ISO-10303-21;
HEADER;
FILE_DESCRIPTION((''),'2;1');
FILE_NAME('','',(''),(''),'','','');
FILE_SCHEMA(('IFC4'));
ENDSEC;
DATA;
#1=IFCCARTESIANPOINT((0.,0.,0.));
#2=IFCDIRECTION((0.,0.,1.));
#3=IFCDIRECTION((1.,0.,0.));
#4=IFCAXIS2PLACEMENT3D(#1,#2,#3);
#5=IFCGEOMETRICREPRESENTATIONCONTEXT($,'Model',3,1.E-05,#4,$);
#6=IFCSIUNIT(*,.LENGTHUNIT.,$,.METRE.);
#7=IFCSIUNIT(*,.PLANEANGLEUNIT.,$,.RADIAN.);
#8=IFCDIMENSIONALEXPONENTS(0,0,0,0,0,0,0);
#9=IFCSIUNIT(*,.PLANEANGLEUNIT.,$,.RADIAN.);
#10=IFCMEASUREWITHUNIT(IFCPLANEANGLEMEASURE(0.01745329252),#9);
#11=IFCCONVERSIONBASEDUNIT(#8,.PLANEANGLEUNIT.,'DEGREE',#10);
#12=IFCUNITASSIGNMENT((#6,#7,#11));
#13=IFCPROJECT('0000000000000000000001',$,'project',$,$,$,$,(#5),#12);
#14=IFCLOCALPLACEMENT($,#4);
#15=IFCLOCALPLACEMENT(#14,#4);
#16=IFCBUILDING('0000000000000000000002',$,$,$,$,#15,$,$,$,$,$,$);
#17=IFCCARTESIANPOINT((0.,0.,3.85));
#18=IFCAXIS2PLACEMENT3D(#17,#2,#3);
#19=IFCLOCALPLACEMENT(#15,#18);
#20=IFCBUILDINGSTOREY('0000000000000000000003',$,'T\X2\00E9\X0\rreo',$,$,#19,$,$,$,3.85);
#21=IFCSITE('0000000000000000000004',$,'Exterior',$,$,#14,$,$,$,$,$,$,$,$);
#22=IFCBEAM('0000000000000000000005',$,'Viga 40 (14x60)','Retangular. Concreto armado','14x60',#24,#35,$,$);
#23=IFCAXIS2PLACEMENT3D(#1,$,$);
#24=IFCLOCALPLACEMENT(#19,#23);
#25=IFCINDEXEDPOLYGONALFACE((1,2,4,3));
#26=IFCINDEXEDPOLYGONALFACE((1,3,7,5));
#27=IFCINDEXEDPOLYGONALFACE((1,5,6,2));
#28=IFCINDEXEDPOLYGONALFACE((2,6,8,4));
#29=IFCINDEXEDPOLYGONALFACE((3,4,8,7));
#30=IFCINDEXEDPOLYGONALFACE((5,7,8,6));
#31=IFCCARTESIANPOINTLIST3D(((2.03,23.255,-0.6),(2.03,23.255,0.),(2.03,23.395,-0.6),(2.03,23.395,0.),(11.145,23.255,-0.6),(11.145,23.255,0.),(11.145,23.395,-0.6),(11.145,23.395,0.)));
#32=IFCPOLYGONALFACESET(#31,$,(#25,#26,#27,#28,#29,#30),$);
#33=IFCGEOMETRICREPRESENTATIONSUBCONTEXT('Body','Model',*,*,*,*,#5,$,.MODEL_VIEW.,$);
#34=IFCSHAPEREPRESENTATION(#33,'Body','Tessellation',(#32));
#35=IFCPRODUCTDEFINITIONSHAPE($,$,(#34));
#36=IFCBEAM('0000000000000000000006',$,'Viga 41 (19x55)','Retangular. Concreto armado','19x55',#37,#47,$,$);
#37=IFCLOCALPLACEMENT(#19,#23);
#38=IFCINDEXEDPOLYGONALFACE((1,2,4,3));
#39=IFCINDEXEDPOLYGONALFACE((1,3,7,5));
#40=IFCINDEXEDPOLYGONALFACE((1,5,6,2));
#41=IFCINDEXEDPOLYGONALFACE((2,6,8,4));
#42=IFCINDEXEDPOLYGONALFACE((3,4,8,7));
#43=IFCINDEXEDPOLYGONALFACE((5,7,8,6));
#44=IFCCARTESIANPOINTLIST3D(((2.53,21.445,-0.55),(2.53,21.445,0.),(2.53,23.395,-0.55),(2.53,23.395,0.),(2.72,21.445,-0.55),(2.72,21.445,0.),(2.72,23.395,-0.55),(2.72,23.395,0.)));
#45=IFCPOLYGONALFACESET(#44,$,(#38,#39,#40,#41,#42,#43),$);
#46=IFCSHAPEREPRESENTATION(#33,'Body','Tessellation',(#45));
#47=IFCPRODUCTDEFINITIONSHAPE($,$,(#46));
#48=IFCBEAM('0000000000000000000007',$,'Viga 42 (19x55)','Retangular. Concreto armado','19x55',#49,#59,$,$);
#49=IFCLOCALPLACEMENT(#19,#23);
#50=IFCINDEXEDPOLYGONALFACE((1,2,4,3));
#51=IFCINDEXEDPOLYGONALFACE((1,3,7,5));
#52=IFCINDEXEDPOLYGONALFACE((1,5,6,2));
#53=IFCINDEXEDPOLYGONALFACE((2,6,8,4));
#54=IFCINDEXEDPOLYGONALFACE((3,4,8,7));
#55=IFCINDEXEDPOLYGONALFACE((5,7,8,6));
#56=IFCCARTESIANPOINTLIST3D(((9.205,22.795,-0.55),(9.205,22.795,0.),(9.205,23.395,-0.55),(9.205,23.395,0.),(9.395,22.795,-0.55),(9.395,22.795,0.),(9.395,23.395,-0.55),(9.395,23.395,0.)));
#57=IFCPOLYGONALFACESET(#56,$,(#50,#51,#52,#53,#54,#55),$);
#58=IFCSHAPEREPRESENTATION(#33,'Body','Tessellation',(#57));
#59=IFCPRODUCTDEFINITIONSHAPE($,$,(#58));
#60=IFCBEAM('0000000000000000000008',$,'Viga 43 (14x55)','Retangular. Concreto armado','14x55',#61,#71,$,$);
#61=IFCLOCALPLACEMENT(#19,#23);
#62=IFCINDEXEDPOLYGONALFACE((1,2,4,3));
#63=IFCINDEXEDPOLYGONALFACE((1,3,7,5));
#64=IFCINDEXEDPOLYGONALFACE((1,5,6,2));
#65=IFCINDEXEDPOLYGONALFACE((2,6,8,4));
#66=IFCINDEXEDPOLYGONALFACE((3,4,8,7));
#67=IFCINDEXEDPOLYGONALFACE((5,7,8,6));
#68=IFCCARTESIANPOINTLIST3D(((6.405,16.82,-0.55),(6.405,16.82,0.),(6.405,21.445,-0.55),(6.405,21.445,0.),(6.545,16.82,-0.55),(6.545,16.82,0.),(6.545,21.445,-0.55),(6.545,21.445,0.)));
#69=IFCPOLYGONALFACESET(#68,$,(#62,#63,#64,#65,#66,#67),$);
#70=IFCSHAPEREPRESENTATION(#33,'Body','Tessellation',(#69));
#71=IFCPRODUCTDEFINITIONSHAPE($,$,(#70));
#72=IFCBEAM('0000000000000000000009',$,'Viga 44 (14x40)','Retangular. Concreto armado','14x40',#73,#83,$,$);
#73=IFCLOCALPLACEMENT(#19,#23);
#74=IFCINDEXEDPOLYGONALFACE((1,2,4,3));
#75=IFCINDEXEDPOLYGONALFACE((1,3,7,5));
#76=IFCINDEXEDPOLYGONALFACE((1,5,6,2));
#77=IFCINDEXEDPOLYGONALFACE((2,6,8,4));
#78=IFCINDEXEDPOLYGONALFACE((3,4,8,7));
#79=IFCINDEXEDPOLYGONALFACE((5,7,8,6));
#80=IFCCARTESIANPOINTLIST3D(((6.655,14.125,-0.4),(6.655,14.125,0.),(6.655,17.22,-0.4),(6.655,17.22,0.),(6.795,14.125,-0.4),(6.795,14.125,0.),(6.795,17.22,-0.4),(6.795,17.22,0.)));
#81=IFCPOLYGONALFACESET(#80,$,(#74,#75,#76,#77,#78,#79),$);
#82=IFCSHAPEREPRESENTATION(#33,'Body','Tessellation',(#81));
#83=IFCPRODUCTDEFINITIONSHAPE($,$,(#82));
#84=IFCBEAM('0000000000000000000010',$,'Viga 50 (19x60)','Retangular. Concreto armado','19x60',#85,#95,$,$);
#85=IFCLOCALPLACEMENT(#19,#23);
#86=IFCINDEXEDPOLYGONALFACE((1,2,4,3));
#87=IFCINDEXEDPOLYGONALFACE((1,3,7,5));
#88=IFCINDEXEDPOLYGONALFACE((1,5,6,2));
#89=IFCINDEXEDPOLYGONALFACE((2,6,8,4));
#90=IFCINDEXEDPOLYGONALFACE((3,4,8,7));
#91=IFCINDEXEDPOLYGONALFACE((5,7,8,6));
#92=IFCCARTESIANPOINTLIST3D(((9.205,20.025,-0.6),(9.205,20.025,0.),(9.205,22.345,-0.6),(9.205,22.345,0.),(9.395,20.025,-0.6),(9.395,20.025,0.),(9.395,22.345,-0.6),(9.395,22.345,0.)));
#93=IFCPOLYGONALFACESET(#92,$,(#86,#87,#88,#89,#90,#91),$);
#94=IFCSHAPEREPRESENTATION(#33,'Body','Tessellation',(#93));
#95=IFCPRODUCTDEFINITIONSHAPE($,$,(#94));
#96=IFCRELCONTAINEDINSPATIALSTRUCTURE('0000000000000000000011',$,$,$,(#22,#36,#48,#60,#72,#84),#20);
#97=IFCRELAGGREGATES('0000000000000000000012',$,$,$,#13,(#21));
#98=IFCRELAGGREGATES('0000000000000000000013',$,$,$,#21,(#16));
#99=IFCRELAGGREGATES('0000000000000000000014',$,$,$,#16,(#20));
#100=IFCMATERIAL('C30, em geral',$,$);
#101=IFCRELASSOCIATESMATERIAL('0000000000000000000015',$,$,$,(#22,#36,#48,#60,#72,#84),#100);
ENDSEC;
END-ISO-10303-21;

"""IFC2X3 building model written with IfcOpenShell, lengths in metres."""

from ifc_helpers import new_model, entity, si_unit, converted_unit, frame, frame_2d, origin_with_axes, place, context, subcontext, project, spatial, rectangle, extrude, material, element, save


model = new_model("IFC2X3")

# Units and contexts
model_context = context("Model", 3, precision=1e-05, world=origin_with_axes())
body_context = subcontext(model_context, "Body", "Model", "MODEL_VIEW")
ifc_project = project(units=[si_unit("LENGTHUNIT", "METRE"), si_unit("PLANEANGLEUNIT", "RADIAN"), converted_unit("PLANEANGLEUNIT", "DEGREE", entity("IfcPlaneAngleMeasure", 0.01745329252), si_unit("PLANEANGLEUNIT", "RADIAN"), dimensions=[0, 0, 0, 0, 0, 0, 0])], contexts=[model_context])

# Site, building, storey
site_placement = place(None, origin_with_axes())
site = spatial("IfcSite", under=ifc_project, at=site_placement, Name="Exterior")
building_placement = place(site_placement, origin_with_axes())
building = spatial("IfcBuilding", under=site, at=building_placement)
storey_placement = place(building_placement, frame((0.0, 0.0, 3.85), z_axis=(0.0, 0.0, 1.0), x_axis=(1.0, 0.0, 0.0)))
storey = spatial("IfcBuildingStorey", under=building, at=storey_placement, Name="Térreo", Elevation=3.85)

# Beams
ifc_material_1 = material(Name="C30, em geral")
beam_1_placement = place(storey_placement, frame((2.03, 23.325, 0.0), z_axis=(1.0, 0.0, 0.0), x_axis=(0.0, 1.0, 0.0)))
element("IfcBeam", 1, at=beam_1_placement, inside=storey, material=ifc_material_1, Name="Viga 40 (14x60)", Description="Retangular. Concreto armado", ObjectType="14x60", context=body_context, shape_type="SweptSolid", body=[
    extrude(rectangle(XDim=0.14, YDim=0.6, at=frame_2d((0.0, -0.3), x_axis=(1.0, 0.0))), origin_with_axes(), (0.0, 0.0, 1.0), 9.115),
])
beam_2_placement = place(storey_placement, frame((2.625, 21.445, 0.0), z_axis=(0.0, 1.0, 0.0), x_axis=(-1.0, 0.0, 0.0)))
element("IfcBeam", 2, at=beam_2_placement, inside=storey, material=ifc_material_1, Name="Viga 41 (19x55)", Description="Retangular. Concreto armado", ObjectType="19x55", context=body_context, shape_type="SweptSolid", body=[
    extrude(rectangle(XDim=0.19, YDim=0.55, at=frame_2d((0.0, -0.275), x_axis=(1.0, 0.0))), origin_with_axes(), (0.0, 0.0, 1.0), 1.95),
])
beam_3_placement = place(storey_placement, frame((9.3, 22.795, 0.0), z_axis=(0.0, 1.0, 0.0), x_axis=(-1.0, 0.0, 0.0)))
element("IfcBeam", 3, at=beam_3_placement, inside=storey, material=ifc_material_1, Name="Viga 42 (19x55)", Description="Retangular. Concreto armado", ObjectType="19x55", context=body_context, shape_type="SweptSolid", body=[
    extrude(rectangle(XDim=0.19, YDim=0.55, at=frame_2d((0.0, -0.275), x_axis=(1.0, 0.0))), origin_with_axes(), (0.0, 0.0, 1.0), 0.6),
])
beam_4_placement = place(storey_placement, frame((6.475, 21.445, 0.0), z_axis=(0.0, -1.0, 0.0), x_axis=(1.0, 0.0, 0.0)))
element("IfcBeam", 4, at=beam_4_placement, inside=storey, material=ifc_material_1, Name="Viga 43 (14x55)", Description="Retangular. Concreto armado", ObjectType="14x55", context=body_context, shape_type="SweptSolid", body=[
    extrude(rectangle(XDim=0.14, YDim=0.55, at=frame_2d((0.0, -0.275), x_axis=(1.0, 0.0))), origin_with_axes(), (0.0, 0.0, 1.0), 4.625),
])
beam_5_placement = place(storey_placement, frame((6.725, 17.22, 0.0), z_axis=(0.0, -1.0, 0.0), x_axis=(1.0, 0.0, 0.0)))
element("IfcBeam", 5, at=beam_5_placement, inside=storey, material=ifc_material_1, Name="Viga 44 (14x40)", Description="Retangular. Concreto armado", ObjectType="14x40", context=body_context, shape_type="SweptSolid", body=[
    extrude(rectangle(XDim=0.14, YDim=0.4, at=frame_2d((0.0, -0.2), x_axis=(1.0, 0.0))), origin_with_axes(), (0.0, 0.0, 1.0), 3.095),
])
beam_6_placement = place(storey_placement, frame((9.3, 20.025, 0.0), z_axis=(0.0, 1.0, 0.0), x_axis=(-1.0, 0.0, 0.0)))
element("IfcBeam", 6, at=beam_6_placement, inside=storey, material=ifc_material_1, Name="Viga 50 (19x60)", Description="Retangular. Concreto armado", ObjectType="19x60", context=body_context, shape_type="SweptSolid", body=[
    extrude(rectangle(XDim=0.19, YDim=0.6, at=frame_2d((0.0, -0.3), x_axis=(1.0, 0.0))), origin_with_axes(), (0.0, 0.0, 1.0), 2.32),
])

save(model, "model.ifc")
